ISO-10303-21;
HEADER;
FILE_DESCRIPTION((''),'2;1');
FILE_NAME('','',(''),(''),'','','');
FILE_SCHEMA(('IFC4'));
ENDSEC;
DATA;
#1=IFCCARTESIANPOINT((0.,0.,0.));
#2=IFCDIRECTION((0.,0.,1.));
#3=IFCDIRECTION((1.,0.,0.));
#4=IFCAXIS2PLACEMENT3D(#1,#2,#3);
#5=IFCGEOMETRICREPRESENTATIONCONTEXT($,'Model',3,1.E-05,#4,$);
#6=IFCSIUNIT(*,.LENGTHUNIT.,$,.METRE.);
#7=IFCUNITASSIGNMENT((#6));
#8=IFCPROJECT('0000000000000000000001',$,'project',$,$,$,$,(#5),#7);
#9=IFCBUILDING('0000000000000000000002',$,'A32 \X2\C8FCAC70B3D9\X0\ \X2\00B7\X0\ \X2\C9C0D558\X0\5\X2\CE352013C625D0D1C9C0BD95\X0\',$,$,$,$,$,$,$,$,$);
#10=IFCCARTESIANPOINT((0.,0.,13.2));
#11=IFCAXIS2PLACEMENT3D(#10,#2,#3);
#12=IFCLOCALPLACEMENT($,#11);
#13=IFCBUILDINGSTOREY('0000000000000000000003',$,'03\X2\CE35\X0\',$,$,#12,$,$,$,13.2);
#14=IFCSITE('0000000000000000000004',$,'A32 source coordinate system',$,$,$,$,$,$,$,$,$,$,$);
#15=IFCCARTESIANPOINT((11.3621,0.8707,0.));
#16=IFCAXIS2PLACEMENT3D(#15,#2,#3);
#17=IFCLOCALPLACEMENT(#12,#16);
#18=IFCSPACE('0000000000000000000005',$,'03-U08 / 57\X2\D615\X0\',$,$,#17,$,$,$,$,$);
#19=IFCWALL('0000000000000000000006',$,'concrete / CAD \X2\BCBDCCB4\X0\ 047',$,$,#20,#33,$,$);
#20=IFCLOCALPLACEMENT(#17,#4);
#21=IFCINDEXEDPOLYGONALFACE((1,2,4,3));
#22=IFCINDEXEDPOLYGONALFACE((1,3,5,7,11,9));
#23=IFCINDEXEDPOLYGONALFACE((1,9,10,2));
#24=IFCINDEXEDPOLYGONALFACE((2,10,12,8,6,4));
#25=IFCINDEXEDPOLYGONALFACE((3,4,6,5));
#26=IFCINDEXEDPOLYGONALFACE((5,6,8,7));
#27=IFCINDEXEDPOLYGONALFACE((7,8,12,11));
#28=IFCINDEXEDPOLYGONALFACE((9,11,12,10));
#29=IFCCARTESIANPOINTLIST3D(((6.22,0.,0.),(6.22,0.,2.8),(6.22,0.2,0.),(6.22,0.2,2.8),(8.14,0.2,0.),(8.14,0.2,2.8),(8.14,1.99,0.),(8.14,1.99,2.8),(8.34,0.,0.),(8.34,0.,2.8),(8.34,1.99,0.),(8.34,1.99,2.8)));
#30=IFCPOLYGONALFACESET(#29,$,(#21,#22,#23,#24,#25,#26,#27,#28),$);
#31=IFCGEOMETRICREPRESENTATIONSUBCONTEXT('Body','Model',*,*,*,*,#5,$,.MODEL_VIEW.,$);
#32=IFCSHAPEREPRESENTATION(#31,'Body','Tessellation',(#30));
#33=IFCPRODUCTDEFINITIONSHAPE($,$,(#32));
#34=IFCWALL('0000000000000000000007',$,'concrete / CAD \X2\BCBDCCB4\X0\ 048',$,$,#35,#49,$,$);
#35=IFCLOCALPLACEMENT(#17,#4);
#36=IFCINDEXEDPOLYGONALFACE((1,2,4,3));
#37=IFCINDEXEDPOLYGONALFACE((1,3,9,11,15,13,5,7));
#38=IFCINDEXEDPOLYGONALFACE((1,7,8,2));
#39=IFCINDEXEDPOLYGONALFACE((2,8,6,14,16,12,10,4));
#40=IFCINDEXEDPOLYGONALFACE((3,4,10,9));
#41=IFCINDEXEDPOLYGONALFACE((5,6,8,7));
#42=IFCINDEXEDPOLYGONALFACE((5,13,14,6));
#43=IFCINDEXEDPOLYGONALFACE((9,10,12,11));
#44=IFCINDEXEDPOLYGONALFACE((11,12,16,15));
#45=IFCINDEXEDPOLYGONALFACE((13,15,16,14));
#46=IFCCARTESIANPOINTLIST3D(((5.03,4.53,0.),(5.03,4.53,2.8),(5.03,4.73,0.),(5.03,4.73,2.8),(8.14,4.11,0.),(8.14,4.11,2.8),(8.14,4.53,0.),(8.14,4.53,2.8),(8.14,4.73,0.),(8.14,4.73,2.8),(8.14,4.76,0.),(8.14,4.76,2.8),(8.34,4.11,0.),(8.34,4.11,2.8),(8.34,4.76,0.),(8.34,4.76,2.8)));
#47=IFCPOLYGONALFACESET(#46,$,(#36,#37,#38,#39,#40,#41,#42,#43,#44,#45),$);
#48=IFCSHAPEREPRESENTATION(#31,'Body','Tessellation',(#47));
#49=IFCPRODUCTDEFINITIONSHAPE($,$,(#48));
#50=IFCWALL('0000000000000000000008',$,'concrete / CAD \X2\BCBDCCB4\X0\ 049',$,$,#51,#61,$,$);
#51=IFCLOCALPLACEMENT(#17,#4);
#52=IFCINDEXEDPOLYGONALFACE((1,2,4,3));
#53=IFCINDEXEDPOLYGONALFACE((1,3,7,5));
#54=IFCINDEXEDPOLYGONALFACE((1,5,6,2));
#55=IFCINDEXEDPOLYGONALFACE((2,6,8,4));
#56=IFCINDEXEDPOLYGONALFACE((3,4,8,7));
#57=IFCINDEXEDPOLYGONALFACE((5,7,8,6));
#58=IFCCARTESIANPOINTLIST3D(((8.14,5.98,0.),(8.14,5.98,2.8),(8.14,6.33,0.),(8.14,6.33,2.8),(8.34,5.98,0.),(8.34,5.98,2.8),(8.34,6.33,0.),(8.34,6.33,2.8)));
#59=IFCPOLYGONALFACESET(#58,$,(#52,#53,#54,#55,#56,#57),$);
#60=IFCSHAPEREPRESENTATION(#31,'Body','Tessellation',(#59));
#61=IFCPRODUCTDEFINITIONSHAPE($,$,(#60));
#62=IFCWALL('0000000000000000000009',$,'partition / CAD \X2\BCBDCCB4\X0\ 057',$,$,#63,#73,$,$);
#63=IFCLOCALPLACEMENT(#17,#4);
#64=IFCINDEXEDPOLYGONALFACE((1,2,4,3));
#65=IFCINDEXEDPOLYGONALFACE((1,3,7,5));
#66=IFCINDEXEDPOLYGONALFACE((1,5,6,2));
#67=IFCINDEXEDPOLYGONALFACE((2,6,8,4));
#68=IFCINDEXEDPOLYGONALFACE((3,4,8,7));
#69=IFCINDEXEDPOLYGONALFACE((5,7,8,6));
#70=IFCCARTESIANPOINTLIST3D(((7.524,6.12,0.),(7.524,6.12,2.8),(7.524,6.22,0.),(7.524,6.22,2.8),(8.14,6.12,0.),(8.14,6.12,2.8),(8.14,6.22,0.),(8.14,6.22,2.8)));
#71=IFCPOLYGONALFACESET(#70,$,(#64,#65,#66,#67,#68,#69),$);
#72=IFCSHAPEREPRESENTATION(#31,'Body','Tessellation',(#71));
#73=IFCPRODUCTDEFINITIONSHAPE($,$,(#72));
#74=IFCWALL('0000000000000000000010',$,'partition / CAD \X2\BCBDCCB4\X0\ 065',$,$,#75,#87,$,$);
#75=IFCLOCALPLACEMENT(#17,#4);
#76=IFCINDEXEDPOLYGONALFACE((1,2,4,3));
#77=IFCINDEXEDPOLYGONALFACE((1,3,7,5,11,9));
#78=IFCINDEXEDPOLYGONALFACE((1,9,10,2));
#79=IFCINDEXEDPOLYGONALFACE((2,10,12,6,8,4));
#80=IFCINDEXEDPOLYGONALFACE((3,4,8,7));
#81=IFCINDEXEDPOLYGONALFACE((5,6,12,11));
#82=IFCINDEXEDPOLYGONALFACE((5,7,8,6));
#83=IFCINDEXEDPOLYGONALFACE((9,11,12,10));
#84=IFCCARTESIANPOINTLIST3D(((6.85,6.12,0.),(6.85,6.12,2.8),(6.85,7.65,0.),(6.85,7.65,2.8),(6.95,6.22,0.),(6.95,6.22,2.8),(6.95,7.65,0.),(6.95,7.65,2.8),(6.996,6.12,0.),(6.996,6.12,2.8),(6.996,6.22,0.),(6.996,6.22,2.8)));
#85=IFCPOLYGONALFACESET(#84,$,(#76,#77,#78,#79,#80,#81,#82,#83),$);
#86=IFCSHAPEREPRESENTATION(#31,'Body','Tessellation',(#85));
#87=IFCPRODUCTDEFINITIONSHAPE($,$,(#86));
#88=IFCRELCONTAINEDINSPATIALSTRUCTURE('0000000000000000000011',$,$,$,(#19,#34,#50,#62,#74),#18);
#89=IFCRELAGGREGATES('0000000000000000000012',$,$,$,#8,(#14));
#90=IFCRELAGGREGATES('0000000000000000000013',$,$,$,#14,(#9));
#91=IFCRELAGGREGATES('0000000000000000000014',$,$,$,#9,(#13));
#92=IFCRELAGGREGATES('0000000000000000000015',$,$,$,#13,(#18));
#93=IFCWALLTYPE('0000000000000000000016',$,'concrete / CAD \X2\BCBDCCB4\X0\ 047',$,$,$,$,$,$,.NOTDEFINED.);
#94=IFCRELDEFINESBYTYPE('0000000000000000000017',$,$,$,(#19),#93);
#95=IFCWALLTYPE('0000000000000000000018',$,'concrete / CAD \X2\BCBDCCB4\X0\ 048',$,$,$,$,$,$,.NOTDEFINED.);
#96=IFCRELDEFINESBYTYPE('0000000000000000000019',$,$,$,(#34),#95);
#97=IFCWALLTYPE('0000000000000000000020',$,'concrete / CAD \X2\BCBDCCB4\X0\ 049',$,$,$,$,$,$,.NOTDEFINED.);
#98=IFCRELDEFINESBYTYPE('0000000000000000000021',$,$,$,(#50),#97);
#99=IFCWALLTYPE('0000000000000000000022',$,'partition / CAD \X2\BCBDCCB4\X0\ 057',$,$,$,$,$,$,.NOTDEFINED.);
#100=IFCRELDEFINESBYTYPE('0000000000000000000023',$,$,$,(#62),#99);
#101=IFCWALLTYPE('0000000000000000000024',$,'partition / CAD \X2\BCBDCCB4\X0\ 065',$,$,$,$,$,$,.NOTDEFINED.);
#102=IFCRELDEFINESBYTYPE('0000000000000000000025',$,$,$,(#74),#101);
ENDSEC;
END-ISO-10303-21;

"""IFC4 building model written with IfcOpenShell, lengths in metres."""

from ifc_helpers import new_model, si_unit, frame, origin, origin_with_axes, place, context, subcontext, project, spatial, polyline, outline, extrude, source, transform, mapped, type_object, type_shapes, element, save


model = new_model("IFC4")

# Units and contexts
model_context = context("Model", 3, precision=1e-05, world=origin_with_axes())
body_context = subcontext(model_context, "Body", "Model", "MODEL_VIEW")
ifc_project = project(units=[si_unit("LENGTHUNIT", "METRE")], contexts=[model_context])

# Site, building, storey, space
storey_placement = place(None, frame((0.0, 0.0, 13.2), z_axis=(0.0, 0.0, 1.0), x_axis=(1.0, 0.0, 0.0)))
space_1_placement = place(storey_placement, frame((11.3621, 0.8707, 0.0), z_axis=(0.0, 0.0, 1.0), x_axis=(1.0, 0.0, 0.0)))
site = spatial("IfcSite", under=ifc_project, Name="A32 source coordinate system")
building = spatial("IfcBuilding", under=site, Name="A32 주거동 · 지하5층–옥탑지붕")
storey = spatial("IfcBuildingStorey", under=building, at=storey_placement, Name="03층", Elevation=13.2)
space_1 = spatial("IfcSpace", under=storey, at=space_1_placement, Name="03-U08 / 57형")

# Walls
wall_type_1 = type_object("IfcWallType", Name="concrete / CAD 벽체 047", PredefinedType="NOTDEFINED")
shared_shape_1 = source(origin(), body_context, "Body", "SweptSolid", [
    extrude(outline(polyline([(8.14, 1.99), (8.34, 1.99), (8.34, 0.0), (6.22, 0.0), (6.22, 0.2), (8.14, 0.2), (8.14, 1.99)])), origin(), (0.0, 0.0, 1.0), 2.8),
])
type_shapes(wall_type_1, [shared_shape_1])
wall_1_placement = place(space_1_placement, origin_with_axes())
element("IfcWall", 1, at=wall_1_placement, inside=space_1, type_object=wall_type_1, Name="concrete / CAD 벽체 047", context=body_context, shape_type="MappedRepresentation", body=[
    mapped(shared_shape_1, transform((0.0, 0.0, 0.0), scale=1.0)),
])
wall_type_2 = type_object("IfcWallType", Name="concrete / CAD 벽체 048", PredefinedType="NOTDEFINED")
shared_shape_2 = source(origin(), body_context, "Body", "SweptSolid", [
    extrude(outline(polyline([(8.14, 4.53), (5.03, 4.53), (5.03, 4.73), (8.14, 4.73), (8.14, 4.76), (8.34, 4.76), (8.34, 4.11), (8.14, 4.11), (8.14, 4.53)])), origin(), (0.0, 0.0, 1.0), 2.8),
])
type_shapes(wall_type_2, [shared_shape_2])
wall_2_placement = place(space_1_placement, origin_with_axes())
element("IfcWall", 2, at=wall_2_placement, inside=space_1, type_object=wall_type_2, Name="concrete / CAD 벽체 048", context=body_context, shape_type="MappedRepresentation", body=[
    mapped(shared_shape_2, transform((0.0, 0.0, 0.0), scale=1.0)),
])
wall_type_3 = type_object("IfcWallType", Name="concrete / CAD 벽체 049", PredefinedType="NOTDEFINED")
shared_shape_3 = source(origin(), body_context, "Body", "SweptSolid", [
    extrude(outline(polyline([(8.34, 6.33), (8.34, 5.98), (8.14, 5.98), (8.14, 6.33), (8.34, 6.33)])), origin(), (0.0, 0.0, 1.0), 2.8),
])
type_shapes(wall_type_3, [shared_shape_3])
wall_3_placement = place(space_1_placement, origin_with_axes())
element("IfcWall", 3, at=wall_3_placement, inside=space_1, type_object=wall_type_3, Name="concrete / CAD 벽체 049", context=body_context, shape_type="MappedRepresentation", body=[
    mapped(shared_shape_3, transform((0.0, 0.0, 0.0), scale=1.0)),
])
wall_type_4 = type_object("IfcWallType", Name="partition / CAD 벽체 057", PredefinedType="NOTDEFINED")
shared_shape_4 = source(origin(), body_context, "Body", "SweptSolid", [
    extrude(outline(polyline([(7.524, 6.22), (8.14, 6.22), (8.14, 6.12), (7.524, 6.12), (7.524, 6.22)])), origin(), (0.0, 0.0, 1.0), 2.8),
])
type_shapes(wall_type_4, [shared_shape_4])
wall_4_placement = place(space_1_placement, origin_with_axes())
element("IfcWall", 4, at=wall_4_placement, inside=space_1, type_object=wall_type_4, Name="partition / CAD 벽체 057", context=body_context, shape_type="MappedRepresentation", body=[
    mapped(shared_shape_4, transform((0.0, 0.0, 0.0), scale=1.0)),
])
wall_type_5 = type_object("IfcWallType", Name="partition / CAD 벽체 065", PredefinedType="NOTDEFINED")
shared_shape_5 = source(origin(), body_context, "Body", "SweptSolid", [
    extrude(outline(polyline([(6.95, 7.65), (6.95, 6.22), (6.996, 6.22), (6.996, 6.12), (6.85, 6.12), (6.85, 7.65), (6.95, 7.65)])), origin(), (0.0, 0.0, 1.0), 2.8),
])
type_shapes(wall_type_5, [shared_shape_5])
wall_5_placement = place(space_1_placement, origin_with_axes())
element("IfcWall", 5, at=wall_5_placement, inside=space_1, type_object=wall_type_5, Name="partition / CAD 벽체 065", context=body_context, shape_type="MappedRepresentation", body=[
    mapped(shared_shape_5, transform((0.0, 0.0, 0.0), scale=1.0)),
])

save(model, "model.ifc")
